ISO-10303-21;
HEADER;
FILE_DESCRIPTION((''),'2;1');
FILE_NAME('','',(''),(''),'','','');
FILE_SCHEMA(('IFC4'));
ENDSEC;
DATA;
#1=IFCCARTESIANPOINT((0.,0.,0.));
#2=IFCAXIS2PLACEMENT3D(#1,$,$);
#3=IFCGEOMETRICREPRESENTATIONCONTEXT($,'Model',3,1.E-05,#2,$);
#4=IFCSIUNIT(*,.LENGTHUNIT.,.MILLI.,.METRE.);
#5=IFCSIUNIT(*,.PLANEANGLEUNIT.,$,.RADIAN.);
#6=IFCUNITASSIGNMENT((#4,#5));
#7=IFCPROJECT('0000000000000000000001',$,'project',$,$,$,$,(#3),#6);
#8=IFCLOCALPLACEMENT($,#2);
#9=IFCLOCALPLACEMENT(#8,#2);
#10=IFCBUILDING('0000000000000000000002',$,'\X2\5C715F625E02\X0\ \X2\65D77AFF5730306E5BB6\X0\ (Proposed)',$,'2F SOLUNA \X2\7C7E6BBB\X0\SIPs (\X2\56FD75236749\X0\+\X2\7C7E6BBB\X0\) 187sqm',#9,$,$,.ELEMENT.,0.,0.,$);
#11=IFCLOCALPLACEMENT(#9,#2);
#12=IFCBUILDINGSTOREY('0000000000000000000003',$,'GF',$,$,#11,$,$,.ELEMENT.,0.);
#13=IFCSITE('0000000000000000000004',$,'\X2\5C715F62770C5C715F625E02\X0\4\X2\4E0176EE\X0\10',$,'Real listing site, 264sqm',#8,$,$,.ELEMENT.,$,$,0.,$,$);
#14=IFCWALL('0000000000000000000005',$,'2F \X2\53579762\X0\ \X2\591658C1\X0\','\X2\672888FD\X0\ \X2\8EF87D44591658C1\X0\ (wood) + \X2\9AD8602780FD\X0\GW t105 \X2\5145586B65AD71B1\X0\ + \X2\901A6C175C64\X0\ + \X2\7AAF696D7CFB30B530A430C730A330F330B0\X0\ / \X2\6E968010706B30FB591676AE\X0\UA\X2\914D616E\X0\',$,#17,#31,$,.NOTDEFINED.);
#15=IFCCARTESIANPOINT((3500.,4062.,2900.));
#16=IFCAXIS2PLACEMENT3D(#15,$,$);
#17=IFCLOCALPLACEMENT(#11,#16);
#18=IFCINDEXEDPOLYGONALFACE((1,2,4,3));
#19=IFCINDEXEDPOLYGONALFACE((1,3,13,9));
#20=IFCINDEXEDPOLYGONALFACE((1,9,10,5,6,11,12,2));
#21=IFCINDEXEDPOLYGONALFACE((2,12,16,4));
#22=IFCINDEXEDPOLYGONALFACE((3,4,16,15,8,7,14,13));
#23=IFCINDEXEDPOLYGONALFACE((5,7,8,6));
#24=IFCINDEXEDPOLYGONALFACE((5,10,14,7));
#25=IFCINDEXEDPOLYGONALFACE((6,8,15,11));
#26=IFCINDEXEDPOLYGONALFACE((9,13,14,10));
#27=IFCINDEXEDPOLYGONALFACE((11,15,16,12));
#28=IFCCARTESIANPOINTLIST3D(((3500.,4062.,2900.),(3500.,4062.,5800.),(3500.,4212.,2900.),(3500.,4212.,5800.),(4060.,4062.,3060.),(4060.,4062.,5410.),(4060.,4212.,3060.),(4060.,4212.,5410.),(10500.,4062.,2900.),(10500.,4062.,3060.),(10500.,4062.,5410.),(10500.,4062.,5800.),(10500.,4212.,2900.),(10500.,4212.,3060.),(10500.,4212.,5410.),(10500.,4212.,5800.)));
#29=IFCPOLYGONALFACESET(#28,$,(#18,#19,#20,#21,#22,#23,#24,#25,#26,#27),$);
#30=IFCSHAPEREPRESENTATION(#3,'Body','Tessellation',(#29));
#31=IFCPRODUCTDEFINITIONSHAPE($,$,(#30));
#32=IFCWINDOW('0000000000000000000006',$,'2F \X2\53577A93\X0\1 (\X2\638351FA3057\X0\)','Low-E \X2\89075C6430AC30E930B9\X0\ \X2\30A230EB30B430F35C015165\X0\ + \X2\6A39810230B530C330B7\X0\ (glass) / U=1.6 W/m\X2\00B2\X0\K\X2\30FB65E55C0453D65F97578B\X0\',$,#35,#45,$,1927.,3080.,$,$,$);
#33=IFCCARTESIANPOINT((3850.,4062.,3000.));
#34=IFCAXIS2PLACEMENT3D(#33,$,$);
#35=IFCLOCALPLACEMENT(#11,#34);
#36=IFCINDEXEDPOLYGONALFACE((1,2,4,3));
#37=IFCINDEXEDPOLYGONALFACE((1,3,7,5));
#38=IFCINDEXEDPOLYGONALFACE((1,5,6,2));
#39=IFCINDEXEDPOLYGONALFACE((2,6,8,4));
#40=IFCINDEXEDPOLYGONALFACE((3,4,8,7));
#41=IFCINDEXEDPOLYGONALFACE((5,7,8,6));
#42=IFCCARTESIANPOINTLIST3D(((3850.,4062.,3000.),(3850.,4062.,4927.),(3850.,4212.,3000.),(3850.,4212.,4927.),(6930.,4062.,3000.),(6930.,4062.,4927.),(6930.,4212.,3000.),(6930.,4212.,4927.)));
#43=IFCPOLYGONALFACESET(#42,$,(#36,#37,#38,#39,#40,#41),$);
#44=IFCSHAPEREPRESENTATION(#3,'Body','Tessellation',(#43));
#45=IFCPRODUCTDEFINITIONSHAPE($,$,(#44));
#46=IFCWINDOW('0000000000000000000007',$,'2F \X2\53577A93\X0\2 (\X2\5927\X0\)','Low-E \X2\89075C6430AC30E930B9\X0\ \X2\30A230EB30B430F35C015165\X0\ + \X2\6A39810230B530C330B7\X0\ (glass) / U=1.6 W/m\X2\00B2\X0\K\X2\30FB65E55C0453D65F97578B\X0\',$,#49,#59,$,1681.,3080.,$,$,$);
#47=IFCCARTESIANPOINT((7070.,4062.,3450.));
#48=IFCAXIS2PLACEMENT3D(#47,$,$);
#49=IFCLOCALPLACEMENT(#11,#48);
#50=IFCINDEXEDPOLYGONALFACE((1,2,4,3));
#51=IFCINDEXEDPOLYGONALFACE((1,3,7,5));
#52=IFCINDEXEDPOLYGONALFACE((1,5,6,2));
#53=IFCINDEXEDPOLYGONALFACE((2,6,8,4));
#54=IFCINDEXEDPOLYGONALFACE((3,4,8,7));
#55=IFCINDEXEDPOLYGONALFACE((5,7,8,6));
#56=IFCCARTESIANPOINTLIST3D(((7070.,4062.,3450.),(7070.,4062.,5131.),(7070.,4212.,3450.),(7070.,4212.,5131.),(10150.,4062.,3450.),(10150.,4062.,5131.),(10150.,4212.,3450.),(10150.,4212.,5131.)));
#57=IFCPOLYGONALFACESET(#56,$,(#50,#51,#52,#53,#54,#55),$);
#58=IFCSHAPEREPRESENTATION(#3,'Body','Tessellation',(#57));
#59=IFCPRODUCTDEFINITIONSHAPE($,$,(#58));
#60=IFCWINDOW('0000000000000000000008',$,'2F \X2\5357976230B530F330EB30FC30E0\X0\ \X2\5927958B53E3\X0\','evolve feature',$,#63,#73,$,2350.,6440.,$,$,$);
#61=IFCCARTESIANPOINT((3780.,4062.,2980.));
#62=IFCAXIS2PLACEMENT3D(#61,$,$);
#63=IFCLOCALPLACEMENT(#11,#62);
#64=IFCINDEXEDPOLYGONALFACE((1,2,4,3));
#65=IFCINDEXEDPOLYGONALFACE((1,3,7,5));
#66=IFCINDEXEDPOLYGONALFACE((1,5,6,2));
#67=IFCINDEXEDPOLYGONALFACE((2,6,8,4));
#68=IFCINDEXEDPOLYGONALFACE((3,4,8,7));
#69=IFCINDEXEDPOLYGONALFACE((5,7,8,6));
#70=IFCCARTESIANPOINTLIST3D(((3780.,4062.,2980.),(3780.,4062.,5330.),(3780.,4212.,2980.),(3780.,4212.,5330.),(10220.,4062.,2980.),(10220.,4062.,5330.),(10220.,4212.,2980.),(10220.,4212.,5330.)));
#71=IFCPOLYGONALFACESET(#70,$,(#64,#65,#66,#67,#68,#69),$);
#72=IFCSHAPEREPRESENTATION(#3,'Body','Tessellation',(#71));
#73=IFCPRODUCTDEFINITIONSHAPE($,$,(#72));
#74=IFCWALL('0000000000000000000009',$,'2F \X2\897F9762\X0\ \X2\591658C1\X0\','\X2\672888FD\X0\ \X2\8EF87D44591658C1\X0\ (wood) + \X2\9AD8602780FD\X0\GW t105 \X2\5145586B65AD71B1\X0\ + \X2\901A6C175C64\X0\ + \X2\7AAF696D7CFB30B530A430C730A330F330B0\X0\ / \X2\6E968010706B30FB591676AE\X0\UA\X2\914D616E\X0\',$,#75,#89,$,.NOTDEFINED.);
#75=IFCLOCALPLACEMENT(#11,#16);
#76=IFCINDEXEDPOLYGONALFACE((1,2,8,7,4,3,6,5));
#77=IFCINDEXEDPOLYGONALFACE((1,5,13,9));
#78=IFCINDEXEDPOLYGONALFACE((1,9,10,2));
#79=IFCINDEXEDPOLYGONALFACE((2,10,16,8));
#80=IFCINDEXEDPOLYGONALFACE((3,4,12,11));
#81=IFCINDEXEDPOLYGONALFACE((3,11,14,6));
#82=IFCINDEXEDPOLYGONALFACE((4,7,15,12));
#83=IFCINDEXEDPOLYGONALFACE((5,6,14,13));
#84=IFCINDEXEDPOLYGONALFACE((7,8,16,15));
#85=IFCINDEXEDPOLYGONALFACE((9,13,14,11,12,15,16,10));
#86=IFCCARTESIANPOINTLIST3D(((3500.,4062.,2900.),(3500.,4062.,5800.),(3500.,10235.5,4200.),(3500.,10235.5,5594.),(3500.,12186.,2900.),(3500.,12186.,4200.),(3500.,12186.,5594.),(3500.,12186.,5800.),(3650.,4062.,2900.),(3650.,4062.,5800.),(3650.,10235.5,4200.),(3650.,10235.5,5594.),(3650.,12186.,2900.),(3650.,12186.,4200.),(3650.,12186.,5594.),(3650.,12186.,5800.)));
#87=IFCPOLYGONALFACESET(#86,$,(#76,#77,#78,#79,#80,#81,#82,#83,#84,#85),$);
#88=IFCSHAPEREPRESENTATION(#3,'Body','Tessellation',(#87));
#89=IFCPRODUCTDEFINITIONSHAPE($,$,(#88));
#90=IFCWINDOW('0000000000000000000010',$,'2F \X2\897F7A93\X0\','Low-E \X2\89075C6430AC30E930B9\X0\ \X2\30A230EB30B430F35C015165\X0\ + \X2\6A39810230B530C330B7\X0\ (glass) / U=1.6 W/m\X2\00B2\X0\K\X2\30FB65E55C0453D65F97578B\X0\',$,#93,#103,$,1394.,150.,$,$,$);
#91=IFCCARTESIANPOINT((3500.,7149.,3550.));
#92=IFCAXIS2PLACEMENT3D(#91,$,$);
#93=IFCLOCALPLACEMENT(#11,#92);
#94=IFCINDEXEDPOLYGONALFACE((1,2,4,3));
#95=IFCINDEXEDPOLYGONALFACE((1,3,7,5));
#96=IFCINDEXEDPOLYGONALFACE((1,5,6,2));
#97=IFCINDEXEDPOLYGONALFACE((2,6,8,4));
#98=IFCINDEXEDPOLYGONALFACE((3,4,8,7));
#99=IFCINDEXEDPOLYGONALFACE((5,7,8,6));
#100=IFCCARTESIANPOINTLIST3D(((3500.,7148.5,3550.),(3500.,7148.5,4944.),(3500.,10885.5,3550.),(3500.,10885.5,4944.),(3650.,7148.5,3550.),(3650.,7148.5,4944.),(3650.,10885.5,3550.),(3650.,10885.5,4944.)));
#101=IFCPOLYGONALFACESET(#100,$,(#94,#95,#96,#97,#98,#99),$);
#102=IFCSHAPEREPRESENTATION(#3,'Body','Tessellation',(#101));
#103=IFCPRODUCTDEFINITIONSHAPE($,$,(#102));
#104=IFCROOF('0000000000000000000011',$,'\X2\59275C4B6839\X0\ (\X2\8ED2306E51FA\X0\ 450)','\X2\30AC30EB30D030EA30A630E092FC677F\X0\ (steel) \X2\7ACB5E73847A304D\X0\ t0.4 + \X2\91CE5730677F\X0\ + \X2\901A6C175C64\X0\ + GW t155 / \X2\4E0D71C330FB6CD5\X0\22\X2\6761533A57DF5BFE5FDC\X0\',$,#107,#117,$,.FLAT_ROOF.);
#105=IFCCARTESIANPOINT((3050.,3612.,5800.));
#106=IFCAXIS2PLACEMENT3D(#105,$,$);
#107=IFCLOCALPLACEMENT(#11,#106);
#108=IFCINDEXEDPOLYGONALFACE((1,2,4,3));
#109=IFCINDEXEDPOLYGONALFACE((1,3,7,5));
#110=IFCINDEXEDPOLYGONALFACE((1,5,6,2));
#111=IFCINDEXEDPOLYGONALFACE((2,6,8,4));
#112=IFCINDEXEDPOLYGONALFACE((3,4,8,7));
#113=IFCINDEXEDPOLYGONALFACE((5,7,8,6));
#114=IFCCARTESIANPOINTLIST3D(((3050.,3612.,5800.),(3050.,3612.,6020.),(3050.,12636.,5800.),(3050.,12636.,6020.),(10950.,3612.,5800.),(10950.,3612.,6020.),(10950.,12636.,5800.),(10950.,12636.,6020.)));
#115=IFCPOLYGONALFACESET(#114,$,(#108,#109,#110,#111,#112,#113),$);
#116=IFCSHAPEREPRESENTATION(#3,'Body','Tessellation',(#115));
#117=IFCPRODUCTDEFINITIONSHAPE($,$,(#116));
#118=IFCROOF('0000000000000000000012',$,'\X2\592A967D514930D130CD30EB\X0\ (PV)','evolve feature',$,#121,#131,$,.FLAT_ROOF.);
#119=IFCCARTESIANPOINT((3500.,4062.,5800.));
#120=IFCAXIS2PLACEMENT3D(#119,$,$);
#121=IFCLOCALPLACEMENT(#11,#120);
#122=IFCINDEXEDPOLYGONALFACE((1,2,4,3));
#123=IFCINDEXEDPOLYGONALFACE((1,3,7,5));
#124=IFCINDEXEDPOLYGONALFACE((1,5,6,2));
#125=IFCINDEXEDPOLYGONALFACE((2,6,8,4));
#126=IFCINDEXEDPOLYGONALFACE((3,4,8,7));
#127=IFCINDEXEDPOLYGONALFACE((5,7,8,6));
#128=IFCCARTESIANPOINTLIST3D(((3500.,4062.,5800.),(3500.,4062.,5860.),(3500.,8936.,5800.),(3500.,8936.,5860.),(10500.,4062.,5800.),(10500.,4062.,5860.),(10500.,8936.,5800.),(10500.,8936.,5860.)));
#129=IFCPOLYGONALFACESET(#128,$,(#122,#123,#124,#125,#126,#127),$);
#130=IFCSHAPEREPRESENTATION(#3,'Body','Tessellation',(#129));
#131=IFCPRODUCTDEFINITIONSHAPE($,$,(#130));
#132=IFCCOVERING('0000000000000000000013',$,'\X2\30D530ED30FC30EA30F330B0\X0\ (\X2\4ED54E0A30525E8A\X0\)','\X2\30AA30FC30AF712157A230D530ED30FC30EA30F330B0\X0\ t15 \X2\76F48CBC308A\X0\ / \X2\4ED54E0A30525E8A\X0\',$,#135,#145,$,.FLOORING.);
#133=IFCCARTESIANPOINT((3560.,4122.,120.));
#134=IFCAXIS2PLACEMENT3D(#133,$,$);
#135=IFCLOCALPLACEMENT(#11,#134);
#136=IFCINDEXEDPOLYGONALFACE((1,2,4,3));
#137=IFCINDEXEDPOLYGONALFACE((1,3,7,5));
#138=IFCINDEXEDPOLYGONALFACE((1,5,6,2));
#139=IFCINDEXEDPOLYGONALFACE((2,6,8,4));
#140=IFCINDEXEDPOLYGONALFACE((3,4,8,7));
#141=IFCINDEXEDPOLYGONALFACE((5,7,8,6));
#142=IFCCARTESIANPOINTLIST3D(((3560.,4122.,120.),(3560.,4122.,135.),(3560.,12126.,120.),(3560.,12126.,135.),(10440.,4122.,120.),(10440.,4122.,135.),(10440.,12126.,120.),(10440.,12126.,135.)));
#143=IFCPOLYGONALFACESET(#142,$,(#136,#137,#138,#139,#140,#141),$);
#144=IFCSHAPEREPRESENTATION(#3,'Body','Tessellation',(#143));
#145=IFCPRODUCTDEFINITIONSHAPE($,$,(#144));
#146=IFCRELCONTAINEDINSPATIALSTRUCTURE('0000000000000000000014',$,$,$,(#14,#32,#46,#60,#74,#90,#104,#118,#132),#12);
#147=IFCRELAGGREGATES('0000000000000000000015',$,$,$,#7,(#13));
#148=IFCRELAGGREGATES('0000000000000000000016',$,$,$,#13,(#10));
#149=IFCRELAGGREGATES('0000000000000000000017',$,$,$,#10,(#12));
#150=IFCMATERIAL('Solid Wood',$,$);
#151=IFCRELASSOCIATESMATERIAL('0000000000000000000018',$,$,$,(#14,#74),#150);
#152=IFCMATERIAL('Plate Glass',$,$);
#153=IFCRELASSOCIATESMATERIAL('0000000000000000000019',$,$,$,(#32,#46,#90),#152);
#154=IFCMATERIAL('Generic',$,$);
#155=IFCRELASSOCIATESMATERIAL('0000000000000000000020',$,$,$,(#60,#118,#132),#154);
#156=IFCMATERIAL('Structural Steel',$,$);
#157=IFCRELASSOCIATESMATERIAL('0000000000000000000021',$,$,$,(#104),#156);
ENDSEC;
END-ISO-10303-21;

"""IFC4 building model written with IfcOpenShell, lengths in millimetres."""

from ifc_helpers import new_model, si_unit, frame, frame_2d, origin, place, context, project, spatial, rectangle, extrude, material, element, fill, save


model = new_model("IFC4")

# Units and contexts
model_context = context("Model", 3, precision=1e-05, world=origin())
ifc_project = project(units=[si_unit("LENGTHUNIT", "METRE", prefix="MILLI"), si_unit("PLANEANGLEUNIT", "RADIAN")], contexts=[model_context])

# Site, building, storey
site_placement = place(None, origin())
site = spatial("IfcSite", under=ifc_project, at=site_placement, Name="山形県山形市4丁目10", ObjectType="Real listing site, 264sqm", CompositionType="ELEMENT", RefElevation=0.0)
building_placement = place(site_placement, origin())
building = spatial("IfcBuilding", under=site, at=building_placement, Name="山形市 旗竿地の家 (Proposed)", ObjectType="2F SOLUNA 籾殻SIPs (国産杉+籾殻) 187sqm", CompositionType="ELEMENT", ElevationOfRefHeight=0.0, ElevationOfTerrain=0.0)
storey_placement = place(building_placement, origin())
storey = spatial("IfcBuildingStorey", under=building, at=storey_placement, Name="GF", CompositionType="ELEMENT", Elevation=0.0)

# Shared definitions
ifc_material_1 = material(Name="Solid Wood")
ifc_material_2 = material(Name="Generic")

# Shared definitions
ifc_material_3 = material(Name="Plate Glass")

# Wall, openings, windows
wall_1_placement = place(storey_placement, frame((3500.0, 4062.0, 2900.0)))
wall_1 = element("IfcWall", 1, at=wall_1_placement, inside=storey, material=ifc_material_1, Name="2F 南面 外壁", Description="木製 軸組外壁 (wood) + 高性能GW t105 充填断熱 + 通気層 + 窯業系サイディング / 準耐火・外皮UA配慮", PredefinedType="NOTDEFINED", context=model_context, shape_type="SweptSolid", body=[
    extrude(rectangle(XDim=7000.0, YDim=150.0, at=frame_2d((3500.0, 75.0))), frame((3500.0, 4062.0, 2900.0)), (0.0, 0.0, 1.0), 2900.0),
])
opening_1_placement = place(storey_placement, frame((3850.0, 4062.0, 3000.0)))
opening_1 = element("IfcOpeningElement", 2, at=opening_1_placement, cuts=wall_1, PredefinedType="NOTDEFINED", context=model_context, shape_type="SweptSolid", body=[
    extrude(rectangle(XDim=3080.0, YDim=150.0, at=frame_2d((1540.0, 75.0))), frame((3850.0, 4062.0, 3000.0)), (0.0, 0.0, 1.0), 1927.0),
])
opening_2_placement = place(storey_placement, frame((7070.0, 4062.0, 3450.0)))
opening_2 = element("IfcOpeningElement", 3, at=opening_2_placement, cuts=wall_1, PredefinedType="NOTDEFINED", context=model_context, shape_type="SweptSolid", body=[
    extrude(rectangle(XDim=3080.0, YDim=150.0, at=frame_2d((1540.0, 75.0))), frame((7070.0, 4062.0, 3450.0)), (0.0, 0.0, 1.0), 1681.0),
])
opening_3_placement = place(storey_placement, frame((3780.0, 4062.0, 2980.0)))
opening_3 = element("IfcOpeningElement", 4, at=opening_3_placement, cuts=wall_1, PredefinedType="NOTDEFINED", context=model_context, shape_type="SweptSolid", body=[
    extrude(rectangle(XDim=6440.0, YDim=150.0, at=frame_2d((3220.0, 75.0))), frame((3780.0, 4062.0, 2980.0)), (0.0, 0.0, 1.0), 2350.0),
])
window_1_placement = place(storey_placement, frame((3850.0, 4062.0, 3000.0)))
window_1 = element("IfcWindow", 5, at=window_1_placement, inside=storey, material=ifc_material_3, Name="2F 南窓1 (掃出し)", Description="Low-E 複層ガラス アルゴン封入 + 樹脂サッシ (glass) / U=1.6 W/m²K・日射取得型", OverallHeight=1927.0, OverallWidth=3080.0, context=model_context, shape_type="SweptSolid", body=[
    extrude(rectangle(XDim=3080.0, YDim=150.0, at=frame_2d((1540.0, 75.0))), frame((3850.0, 4062.0, 3000.0)), (0.0, 0.0, 1.0), 1927.0),
])
fill(opening_1, window_1)
window_2_placement = place(storey_placement, frame((7070.0, 4062.0, 3450.0)))
window_2 = element("IfcWindow", 6, at=window_2_placement, inside=storey, material=ifc_material_3, Name="2F 南窓2 (大)", Description="Low-E 複層ガラス アルゴン封入 + 樹脂サッシ (glass) / U=1.6 W/m²K・日射取得型", OverallHeight=1681.0, OverallWidth=3080.0, context=model_context, shape_type="SweptSolid", body=[
    extrude(rectangle(XDim=3080.0, YDim=150.0, at=frame_2d((1540.0, 75.0))), frame((7070.0, 4062.0, 3450.0)), (0.0, 0.0, 1.0), 1681.0),
])
fill(opening_2, window_2)
window_3_placement = place(storey_placement, frame((3780.0, 4062.0, 2980.0)))
window_3 = element("IfcWindow", 7, at=window_3_placement, inside=storey, material=ifc_material_2, Name="2F 南面サンルーム 大開口", Description="evolve feature", OverallHeight=2350.0, OverallWidth=6440.0, context=model_context, shape_type="SweptSolid", body=[
    extrude(rectangle(XDim=6440.0, YDim=150.0, at=frame_2d((3220.0, 75.0))), frame((3780.0, 4062.0, 2980.0)), (0.0, 0.0, 1.0), 2350.0),
])
fill(opening_3, window_3)

# Wall, opening, window
wall_2_placement = place(storey_placement, frame((3500.0, 4062.0, 2900.0)))
wall_2 = element("IfcWall", 8, at=wall_2_placement, inside=storey, material=ifc_material_1, Name="2F 西面 外壁", Description="木製 軸組外壁 (wood) + 高性能GW t105 充填断熱 + 通気層 + 窯業系サイディング / 準耐火・外皮UA配慮", PredefinedType="NOTDEFINED", context=model_context, shape_type="SweptSolid", body=[
    extrude(rectangle(XDim=150.0, YDim=8124.0, at=frame_2d((75.0, 4062.0))), frame((3500.0, 4062.0, 2900.0)), (0.0, 0.0, 1.0), 2900.0),
])
opening_4_placement = place(storey_placement, frame((3500.0, 7149.0, 3550.0)))
opening_4 = element("IfcOpeningElement", 9, at=opening_4_placement, cuts=wall_2, PredefinedType="NOTDEFINED", context=model_context, shape_type="SweptSolid", body=[
    extrude(rectangle(XDim=150.0, YDim=3737.0, at=frame_2d((75.0, 1868.0))), frame((3500.0, 7149.0, 3550.0)), (0.0, 0.0, 1.0), 1394.0),
])
window_4_placement = place(storey_placement, frame((3500.0, 7149.0, 3550.0)))
window_4 = element("IfcWindow", 10, at=window_4_placement, inside=storey, material=ifc_material_3, Name="2F 西窓", Description="Low-E 複層ガラス アルゴン封入 + 樹脂サッシ (glass) / U=1.6 W/m²K・日射取得型", OverallHeight=1394.0, OverallWidth=150.0, context=model_context, shape_type="SweptSolid", body=[
    extrude(rectangle(XDim=150.0, YDim=3737.0, at=frame_2d((75.0, 1868.0))), frame((3500.0, 7149.0, 3550.0)), (0.0, 0.0, 1.0), 1394.0),
])
fill(opening_4, window_4)

# Roofs
ifc_material_4 = material(Name="Structural Steel")
roof_1_placement = place(storey_placement, frame((3050.0, 3612.0, 5800.0)))
element("IfcRoof", 11, at=roof_1_placement, inside=storey, material=ifc_material_4, Name="大屋根 (軒の出 450)", Description="ガルバリウム鋼板 (steel) 立平葺き t0.4 + 野地板 + 通気層 + GW t155 / 不燃・法22条区域対応", PredefinedType="FLAT_ROOF", context=model_context, shape_type="SweptSolid", body=[
    extrude(rectangle(XDim=7900.0, YDim=9024.0, at=frame_2d((3950.0, 4512.0))), frame((3050.0, 3612.0, 5800.0)), (0.0, 0.0, 1.0), 220.0),
])
roof_2_placement = place(storey_placement, frame((3500.0, 4062.0, 5800.0)))
element("IfcRoof", 12, at=roof_2_placement, inside=storey, material=ifc_material_2, Name="太陽光パネル (PV)", Description="evolve feature", PredefinedType="FLAT_ROOF", context=model_context, shape_type="SweptSolid", body=[
    extrude(rectangle(XDim=7000.0, YDim=4874.0, at=frame_2d((3500.0, 2437.0))), frame((3500.0, 4062.0, 5800.0)), (0.0, 0.0, 1.0), 60.0),
])

# Covering
covering_placement = place(storey_placement, frame((3560.0, 4122.0, 120.0)))
element("IfcCovering", 13, at=covering_placement, inside=storey, material=ifc_material_2, Name="フローリング (仕上げ床)", Description="オーク無垢フローリング t15 直貼り / 仕上げ床", PredefinedType="FLOORING", context=model_context, shape_type="SweptSolid", body=[
    extrude(rectangle(XDim=6880.0, YDim=8004.0, at=frame_2d((3440.0, 4002.0))), frame((3560.0, 4122.0, 120.0)), (0.0, 0.0, 1.0), 15.0),
])

save(model, "model.ifc")
